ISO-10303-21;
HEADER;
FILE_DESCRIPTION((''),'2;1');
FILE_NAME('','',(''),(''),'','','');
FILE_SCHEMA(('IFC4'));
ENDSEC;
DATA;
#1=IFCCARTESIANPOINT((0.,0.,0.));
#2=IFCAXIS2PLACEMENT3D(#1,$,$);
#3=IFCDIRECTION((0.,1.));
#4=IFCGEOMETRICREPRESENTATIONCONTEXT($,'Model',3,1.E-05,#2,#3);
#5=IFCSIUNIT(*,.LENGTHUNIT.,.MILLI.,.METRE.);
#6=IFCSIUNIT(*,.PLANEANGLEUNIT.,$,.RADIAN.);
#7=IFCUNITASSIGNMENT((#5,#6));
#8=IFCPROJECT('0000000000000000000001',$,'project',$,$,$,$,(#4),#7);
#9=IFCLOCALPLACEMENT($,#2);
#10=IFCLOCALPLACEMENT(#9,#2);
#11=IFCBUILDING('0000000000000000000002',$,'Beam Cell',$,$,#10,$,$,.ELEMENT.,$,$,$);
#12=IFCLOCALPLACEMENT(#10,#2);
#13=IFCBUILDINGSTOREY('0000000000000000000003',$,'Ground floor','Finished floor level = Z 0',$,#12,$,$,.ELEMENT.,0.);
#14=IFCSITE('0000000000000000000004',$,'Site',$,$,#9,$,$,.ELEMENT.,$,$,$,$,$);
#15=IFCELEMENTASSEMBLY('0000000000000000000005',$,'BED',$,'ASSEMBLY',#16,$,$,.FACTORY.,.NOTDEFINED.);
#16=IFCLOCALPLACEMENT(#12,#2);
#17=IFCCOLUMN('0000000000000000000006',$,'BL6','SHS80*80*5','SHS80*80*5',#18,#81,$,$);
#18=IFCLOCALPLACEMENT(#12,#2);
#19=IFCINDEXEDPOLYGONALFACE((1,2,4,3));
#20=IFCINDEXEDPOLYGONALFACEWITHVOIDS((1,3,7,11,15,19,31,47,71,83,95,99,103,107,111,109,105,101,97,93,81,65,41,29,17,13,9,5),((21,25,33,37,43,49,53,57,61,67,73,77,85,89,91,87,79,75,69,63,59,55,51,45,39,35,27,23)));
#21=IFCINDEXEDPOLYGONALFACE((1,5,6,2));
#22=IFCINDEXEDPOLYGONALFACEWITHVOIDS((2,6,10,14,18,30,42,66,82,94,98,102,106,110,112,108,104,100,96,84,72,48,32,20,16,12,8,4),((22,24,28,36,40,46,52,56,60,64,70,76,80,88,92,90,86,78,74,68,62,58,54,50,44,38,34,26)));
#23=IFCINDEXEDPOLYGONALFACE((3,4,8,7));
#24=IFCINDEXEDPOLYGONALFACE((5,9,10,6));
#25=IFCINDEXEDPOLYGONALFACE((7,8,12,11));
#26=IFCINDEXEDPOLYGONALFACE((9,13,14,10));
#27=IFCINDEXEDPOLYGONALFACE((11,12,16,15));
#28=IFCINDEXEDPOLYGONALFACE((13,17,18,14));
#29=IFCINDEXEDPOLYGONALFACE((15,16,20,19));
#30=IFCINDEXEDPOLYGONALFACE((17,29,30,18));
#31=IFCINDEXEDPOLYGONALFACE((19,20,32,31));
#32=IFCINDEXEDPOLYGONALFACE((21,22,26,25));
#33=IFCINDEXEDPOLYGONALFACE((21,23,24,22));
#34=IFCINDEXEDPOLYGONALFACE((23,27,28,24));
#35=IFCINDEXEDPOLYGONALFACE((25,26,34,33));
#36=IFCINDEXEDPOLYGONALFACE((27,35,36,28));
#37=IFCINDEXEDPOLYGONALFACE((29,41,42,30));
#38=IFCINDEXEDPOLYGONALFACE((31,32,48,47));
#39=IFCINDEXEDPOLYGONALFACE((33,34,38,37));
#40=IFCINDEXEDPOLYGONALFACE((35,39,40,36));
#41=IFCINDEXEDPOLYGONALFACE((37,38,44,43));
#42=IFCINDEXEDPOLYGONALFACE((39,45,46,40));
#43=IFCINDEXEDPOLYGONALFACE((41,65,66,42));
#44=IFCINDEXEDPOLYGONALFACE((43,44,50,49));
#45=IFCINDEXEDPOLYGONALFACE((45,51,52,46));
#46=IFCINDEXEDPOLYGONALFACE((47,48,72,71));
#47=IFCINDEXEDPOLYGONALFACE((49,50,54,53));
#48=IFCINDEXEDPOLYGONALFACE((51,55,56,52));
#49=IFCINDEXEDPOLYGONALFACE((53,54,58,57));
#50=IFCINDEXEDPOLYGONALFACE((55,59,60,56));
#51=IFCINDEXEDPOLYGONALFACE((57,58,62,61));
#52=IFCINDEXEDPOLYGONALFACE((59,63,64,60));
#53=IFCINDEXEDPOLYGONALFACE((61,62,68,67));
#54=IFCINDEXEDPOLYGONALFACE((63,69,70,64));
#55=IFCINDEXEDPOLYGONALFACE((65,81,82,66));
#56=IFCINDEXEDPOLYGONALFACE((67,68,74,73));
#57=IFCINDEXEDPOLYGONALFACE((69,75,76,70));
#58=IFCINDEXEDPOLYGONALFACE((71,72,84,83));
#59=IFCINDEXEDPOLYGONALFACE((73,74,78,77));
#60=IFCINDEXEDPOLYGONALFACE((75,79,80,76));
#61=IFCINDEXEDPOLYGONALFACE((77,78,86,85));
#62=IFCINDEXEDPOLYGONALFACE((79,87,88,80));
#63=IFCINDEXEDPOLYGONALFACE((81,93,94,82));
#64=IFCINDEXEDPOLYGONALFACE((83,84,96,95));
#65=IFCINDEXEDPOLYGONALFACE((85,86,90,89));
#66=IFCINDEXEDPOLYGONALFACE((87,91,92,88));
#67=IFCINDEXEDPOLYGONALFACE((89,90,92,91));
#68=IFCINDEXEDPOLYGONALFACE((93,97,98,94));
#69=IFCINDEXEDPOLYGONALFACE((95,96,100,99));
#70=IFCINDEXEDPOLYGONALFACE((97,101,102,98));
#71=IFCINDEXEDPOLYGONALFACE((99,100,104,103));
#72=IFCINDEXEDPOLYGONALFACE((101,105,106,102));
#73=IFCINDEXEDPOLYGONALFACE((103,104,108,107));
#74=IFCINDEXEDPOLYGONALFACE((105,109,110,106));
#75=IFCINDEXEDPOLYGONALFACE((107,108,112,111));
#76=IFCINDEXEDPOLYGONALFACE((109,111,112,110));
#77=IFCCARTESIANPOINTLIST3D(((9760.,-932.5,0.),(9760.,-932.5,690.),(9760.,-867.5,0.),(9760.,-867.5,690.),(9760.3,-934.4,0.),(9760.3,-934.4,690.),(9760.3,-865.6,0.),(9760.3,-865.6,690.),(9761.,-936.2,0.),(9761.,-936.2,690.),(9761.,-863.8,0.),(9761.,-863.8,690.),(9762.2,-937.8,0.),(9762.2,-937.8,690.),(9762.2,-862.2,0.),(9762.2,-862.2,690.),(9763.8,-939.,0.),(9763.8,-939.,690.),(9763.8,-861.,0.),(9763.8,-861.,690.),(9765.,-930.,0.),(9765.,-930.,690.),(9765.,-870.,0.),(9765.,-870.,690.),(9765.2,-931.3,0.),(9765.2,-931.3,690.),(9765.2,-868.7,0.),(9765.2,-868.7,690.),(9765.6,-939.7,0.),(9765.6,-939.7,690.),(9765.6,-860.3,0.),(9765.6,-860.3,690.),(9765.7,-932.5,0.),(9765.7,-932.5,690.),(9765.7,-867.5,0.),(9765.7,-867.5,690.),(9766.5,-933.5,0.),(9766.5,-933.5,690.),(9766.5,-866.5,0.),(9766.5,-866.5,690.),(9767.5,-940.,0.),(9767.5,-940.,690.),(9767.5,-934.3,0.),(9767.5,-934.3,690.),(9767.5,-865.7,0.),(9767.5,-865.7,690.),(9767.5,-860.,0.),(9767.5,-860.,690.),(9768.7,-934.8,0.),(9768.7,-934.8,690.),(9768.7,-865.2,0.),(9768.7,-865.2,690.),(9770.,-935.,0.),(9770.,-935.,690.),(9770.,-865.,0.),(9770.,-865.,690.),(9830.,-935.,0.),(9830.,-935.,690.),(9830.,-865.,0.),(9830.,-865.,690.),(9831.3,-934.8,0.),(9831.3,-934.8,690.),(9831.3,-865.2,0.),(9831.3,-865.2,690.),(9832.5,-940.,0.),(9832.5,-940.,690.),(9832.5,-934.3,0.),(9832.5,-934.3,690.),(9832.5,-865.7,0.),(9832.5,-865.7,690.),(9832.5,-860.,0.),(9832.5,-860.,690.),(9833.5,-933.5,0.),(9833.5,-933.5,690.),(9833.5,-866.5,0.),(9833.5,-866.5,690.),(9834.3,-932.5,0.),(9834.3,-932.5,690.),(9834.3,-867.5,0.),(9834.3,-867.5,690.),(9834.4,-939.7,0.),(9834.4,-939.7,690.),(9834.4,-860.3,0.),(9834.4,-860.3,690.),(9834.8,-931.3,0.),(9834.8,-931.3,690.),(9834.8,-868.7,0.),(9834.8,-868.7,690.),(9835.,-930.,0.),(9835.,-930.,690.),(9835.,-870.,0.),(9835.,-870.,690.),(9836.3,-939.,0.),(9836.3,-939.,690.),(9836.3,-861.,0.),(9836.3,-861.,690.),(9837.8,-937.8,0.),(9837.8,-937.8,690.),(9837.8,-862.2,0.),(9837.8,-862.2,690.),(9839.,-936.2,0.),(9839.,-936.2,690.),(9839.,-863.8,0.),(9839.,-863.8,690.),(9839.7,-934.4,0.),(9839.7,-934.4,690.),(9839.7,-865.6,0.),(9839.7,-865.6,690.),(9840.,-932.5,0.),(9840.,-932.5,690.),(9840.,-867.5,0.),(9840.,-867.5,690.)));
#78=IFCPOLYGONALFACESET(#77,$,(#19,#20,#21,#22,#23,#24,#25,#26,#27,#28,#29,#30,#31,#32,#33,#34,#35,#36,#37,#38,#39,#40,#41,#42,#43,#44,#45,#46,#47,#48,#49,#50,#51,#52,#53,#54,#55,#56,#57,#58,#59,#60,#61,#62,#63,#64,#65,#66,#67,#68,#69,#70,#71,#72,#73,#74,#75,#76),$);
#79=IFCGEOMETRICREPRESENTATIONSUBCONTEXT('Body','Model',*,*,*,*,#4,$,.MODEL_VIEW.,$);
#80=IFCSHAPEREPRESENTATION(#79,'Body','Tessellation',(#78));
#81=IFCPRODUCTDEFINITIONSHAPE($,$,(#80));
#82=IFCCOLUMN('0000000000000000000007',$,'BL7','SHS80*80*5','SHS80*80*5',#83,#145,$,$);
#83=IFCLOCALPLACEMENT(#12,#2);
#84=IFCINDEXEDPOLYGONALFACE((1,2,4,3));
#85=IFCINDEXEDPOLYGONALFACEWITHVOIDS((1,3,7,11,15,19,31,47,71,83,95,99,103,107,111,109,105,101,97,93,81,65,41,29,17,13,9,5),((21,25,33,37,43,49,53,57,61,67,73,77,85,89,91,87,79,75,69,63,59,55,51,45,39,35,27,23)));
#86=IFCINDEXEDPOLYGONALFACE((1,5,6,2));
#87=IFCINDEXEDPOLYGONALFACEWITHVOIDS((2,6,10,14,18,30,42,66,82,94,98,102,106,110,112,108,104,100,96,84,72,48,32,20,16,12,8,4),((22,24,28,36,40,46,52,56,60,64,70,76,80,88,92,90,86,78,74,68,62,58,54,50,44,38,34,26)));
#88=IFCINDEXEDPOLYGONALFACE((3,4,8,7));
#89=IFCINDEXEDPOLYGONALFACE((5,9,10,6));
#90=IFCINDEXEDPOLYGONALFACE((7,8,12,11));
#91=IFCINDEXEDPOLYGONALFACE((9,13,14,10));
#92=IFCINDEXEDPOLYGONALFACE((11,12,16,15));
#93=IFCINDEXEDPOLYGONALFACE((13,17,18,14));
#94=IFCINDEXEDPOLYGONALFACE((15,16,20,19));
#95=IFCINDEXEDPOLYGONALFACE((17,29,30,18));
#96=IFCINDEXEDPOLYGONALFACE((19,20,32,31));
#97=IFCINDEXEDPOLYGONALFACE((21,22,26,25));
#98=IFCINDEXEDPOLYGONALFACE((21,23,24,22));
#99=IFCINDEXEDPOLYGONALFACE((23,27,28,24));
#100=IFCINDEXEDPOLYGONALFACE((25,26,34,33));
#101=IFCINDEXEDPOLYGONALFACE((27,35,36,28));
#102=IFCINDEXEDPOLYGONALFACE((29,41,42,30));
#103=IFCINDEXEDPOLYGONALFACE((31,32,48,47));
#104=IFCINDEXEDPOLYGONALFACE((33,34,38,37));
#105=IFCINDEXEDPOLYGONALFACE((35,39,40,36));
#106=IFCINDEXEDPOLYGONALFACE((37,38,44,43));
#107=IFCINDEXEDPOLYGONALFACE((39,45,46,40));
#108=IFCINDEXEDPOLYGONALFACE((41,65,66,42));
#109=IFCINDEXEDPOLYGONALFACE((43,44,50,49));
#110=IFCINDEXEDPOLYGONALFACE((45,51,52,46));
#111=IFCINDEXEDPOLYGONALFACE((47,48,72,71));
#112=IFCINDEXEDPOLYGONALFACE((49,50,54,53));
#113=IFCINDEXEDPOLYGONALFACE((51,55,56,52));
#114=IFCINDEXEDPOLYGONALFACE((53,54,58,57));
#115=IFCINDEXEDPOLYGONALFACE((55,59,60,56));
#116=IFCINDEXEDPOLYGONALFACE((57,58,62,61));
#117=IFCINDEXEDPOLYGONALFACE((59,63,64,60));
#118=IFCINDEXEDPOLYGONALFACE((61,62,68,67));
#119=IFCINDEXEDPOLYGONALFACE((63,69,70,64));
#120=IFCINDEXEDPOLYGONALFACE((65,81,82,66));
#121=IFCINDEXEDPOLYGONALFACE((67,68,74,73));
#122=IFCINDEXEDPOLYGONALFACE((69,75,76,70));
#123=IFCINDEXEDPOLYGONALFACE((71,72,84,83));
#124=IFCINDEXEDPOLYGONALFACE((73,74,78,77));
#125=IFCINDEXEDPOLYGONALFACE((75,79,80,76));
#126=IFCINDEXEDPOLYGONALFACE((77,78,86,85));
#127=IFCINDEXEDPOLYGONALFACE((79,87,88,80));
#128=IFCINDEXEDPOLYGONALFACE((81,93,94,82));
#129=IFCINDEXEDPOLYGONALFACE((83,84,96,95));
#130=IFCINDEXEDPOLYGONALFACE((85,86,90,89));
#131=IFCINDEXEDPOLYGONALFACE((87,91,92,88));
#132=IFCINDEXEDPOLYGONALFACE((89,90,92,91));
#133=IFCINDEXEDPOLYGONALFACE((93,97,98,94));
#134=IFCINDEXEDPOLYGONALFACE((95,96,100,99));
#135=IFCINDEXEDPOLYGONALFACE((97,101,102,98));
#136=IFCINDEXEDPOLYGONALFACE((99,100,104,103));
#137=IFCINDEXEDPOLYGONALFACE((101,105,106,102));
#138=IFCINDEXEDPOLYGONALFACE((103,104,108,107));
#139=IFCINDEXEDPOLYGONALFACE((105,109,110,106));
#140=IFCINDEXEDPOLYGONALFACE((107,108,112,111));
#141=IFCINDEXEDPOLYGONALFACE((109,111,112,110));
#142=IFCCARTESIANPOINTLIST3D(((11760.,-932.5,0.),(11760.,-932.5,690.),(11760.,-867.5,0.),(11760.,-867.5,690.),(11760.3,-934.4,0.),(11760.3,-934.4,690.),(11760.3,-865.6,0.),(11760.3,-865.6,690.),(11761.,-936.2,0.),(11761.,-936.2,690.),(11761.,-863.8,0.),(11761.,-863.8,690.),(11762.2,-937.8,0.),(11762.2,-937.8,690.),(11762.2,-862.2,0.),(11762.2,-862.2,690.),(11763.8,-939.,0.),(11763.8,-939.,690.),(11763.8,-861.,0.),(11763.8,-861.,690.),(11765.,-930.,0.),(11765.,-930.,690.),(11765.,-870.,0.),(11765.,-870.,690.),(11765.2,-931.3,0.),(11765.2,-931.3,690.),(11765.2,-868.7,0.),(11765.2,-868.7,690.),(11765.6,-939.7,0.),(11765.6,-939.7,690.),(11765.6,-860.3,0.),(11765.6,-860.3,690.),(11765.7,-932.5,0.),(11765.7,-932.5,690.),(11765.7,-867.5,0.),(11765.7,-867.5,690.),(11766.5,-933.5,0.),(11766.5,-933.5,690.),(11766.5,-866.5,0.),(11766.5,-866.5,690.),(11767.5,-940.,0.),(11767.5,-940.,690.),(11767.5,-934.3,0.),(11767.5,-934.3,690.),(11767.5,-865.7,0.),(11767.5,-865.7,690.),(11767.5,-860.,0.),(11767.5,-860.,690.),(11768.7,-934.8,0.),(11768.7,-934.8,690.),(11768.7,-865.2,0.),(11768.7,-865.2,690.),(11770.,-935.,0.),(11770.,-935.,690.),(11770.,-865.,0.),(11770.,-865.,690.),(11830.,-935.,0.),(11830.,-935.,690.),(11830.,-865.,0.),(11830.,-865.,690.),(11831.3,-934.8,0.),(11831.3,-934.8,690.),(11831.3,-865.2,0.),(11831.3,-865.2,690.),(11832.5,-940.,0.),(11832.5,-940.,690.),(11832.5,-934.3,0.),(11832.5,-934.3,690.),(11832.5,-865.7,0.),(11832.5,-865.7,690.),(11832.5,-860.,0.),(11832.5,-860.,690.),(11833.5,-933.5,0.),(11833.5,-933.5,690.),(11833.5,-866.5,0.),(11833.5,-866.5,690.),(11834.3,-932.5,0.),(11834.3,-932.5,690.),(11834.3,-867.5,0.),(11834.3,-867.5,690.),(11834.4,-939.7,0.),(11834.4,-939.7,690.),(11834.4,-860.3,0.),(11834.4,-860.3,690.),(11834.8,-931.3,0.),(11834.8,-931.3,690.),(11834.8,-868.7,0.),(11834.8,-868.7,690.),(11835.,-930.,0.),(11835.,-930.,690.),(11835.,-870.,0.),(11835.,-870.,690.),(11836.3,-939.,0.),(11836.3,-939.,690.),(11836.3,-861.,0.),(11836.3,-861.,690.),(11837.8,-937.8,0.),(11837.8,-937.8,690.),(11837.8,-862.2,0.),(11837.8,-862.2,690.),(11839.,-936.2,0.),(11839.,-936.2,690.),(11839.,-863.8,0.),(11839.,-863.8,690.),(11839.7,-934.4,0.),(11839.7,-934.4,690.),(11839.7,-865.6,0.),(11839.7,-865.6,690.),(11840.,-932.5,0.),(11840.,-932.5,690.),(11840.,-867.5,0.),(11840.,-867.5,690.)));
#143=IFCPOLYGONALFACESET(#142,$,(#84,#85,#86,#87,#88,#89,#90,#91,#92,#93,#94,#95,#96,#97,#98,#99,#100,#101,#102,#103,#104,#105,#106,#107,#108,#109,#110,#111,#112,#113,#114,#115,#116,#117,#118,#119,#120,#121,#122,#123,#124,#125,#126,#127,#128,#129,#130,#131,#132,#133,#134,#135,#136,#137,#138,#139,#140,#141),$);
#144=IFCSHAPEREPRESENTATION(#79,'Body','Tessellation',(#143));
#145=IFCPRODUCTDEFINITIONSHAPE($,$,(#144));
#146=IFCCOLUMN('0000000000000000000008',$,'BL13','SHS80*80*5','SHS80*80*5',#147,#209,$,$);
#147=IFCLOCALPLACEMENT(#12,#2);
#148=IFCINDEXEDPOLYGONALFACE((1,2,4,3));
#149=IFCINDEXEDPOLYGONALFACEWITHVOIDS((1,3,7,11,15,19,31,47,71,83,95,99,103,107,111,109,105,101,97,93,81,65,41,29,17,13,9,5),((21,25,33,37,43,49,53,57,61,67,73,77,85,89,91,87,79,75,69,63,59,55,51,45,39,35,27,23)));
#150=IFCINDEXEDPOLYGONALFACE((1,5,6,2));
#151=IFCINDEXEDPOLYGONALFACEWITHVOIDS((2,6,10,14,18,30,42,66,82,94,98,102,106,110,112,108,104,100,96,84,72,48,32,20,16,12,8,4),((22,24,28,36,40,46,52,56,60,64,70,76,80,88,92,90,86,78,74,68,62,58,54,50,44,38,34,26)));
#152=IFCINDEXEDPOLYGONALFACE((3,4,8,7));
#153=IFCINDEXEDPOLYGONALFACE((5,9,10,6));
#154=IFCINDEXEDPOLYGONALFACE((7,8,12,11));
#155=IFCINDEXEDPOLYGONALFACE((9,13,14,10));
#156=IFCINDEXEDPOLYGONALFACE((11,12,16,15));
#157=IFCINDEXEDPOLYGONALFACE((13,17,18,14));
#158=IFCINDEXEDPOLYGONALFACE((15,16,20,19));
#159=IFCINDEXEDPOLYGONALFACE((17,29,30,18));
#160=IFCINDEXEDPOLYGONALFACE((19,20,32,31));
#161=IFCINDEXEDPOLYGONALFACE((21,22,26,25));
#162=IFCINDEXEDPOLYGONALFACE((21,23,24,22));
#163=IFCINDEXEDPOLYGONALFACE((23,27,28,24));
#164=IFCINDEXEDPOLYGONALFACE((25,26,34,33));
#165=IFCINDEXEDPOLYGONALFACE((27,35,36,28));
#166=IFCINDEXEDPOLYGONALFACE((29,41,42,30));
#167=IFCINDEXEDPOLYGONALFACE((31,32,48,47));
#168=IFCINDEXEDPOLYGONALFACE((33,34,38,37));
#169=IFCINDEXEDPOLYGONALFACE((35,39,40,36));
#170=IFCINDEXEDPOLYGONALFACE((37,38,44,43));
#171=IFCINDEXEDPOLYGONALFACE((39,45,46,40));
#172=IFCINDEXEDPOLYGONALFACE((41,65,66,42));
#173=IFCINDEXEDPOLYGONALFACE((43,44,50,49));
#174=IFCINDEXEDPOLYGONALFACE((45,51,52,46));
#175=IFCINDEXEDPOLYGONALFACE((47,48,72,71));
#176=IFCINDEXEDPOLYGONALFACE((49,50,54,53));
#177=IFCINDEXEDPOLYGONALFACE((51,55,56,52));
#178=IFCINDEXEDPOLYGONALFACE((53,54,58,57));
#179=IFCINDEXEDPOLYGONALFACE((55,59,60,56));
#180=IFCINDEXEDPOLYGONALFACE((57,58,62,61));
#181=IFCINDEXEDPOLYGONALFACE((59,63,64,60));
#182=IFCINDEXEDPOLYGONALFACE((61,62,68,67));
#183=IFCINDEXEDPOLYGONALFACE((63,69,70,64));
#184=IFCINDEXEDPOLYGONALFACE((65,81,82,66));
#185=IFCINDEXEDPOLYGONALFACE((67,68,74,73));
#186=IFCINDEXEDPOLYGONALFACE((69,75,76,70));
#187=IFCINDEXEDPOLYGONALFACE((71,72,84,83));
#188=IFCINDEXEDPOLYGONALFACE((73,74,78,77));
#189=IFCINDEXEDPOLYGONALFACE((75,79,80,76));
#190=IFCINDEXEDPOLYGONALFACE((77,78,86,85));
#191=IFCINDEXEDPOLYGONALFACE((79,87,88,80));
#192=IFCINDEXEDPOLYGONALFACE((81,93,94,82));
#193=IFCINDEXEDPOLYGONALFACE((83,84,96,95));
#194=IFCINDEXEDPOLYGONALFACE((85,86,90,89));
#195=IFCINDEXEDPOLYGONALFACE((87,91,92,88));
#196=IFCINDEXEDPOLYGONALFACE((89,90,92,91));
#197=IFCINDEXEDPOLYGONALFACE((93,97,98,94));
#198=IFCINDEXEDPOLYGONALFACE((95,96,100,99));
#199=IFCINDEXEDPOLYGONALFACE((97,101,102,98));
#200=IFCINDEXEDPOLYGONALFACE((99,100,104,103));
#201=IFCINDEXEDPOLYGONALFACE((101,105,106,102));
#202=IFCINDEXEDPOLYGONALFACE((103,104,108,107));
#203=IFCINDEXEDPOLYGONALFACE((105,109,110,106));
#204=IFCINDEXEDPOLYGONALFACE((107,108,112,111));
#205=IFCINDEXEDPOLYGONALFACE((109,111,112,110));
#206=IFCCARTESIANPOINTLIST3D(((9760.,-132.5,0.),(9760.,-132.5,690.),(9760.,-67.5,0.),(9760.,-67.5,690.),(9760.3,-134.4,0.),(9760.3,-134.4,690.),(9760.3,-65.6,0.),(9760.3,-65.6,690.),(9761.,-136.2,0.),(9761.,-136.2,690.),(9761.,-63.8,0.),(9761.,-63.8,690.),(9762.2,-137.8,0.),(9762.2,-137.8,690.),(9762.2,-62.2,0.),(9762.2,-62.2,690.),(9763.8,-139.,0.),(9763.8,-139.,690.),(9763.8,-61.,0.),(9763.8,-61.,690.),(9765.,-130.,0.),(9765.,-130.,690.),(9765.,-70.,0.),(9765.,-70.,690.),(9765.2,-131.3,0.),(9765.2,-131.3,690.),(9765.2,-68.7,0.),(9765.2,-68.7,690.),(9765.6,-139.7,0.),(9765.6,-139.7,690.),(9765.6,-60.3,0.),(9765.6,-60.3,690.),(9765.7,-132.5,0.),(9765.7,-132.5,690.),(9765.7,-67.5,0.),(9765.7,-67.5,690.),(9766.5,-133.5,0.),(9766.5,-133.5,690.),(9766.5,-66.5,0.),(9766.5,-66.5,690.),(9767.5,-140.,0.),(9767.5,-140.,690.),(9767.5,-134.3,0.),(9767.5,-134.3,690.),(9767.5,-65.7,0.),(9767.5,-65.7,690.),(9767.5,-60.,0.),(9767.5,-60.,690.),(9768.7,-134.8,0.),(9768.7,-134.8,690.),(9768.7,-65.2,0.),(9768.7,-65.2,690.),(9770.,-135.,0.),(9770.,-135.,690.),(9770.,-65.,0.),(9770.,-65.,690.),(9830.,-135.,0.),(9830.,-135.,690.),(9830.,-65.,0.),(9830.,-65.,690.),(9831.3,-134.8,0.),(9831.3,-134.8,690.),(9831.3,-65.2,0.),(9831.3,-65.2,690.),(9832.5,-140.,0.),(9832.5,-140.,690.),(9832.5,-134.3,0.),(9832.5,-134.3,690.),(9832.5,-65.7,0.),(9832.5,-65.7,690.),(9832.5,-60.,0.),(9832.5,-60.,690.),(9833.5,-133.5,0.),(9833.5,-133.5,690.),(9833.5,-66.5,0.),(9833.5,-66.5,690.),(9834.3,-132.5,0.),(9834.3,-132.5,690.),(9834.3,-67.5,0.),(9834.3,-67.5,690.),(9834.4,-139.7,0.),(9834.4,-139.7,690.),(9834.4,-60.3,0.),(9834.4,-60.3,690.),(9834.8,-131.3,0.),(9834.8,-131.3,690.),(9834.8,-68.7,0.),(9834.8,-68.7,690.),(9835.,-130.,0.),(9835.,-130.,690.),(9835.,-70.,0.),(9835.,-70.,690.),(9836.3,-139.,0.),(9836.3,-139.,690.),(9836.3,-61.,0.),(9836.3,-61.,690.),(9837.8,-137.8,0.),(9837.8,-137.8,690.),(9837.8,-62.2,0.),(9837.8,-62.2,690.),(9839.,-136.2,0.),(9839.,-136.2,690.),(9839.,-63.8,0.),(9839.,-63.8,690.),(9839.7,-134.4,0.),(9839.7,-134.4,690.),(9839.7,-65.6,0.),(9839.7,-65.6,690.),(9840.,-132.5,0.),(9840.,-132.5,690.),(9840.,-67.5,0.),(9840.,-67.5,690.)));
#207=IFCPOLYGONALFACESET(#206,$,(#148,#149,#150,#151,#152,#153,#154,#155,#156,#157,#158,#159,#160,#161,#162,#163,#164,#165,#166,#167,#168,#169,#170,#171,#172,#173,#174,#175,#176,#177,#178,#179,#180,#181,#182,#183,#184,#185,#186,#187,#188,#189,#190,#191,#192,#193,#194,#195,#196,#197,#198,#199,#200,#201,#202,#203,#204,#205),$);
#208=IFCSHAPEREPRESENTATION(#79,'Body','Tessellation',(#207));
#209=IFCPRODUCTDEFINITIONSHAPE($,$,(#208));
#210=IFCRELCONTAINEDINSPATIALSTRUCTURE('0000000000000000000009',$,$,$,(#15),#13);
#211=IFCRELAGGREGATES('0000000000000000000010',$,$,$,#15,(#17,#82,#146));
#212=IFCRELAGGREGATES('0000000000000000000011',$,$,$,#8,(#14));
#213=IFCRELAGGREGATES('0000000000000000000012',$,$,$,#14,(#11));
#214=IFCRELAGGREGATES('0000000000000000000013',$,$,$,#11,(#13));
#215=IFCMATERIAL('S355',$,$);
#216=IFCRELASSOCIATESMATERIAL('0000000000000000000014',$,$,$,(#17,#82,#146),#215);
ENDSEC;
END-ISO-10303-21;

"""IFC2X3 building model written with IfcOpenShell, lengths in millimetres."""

from ifc_helpers import new_model, si_unit, direction, frame, origin, origin_2d, place, context, subcontext, project, spatial, hollow_rectangle, extrude, material, element, aggregate, save


model = new_model("IFC2X3")

# Units and contexts
model_context = context("Model", 3, precision=1e-05, world=origin(), true_north=direction((0.0, 1.0)))
body_context = subcontext(model_context, "Body", "Model", "MODEL_VIEW")
ifc_project = project(units=[si_unit("LENGTHUNIT", "METRE", prefix="MILLI"), si_unit("PLANEANGLEUNIT", "RADIAN")], contexts=[model_context])

# Site, building, storey
site_placement = place(None, origin())
site = spatial("IfcSite", under=ifc_project, at=site_placement, Name="Site", CompositionType="ELEMENT")
building_placement = place(site_placement, origin())
building = spatial("IfcBuilding", under=site, at=building_placement, Name="Beam Cell", CompositionType="ELEMENT")
storey_placement = place(building_placement, origin())
storey = spatial("IfcBuildingStorey", under=building, at=storey_placement, Name="Ground floor", Description="Finished floor level = Z 0", CompositionType="ELEMENT", Elevation=0.0)

# Element assembly, columns
ifc_material = material(Name="S355")
assembly_1_placement = place(storey_placement, origin())
assembly_1 = element("IfcElementAssembly", 1, at=assembly_1_placement, inside=storey, Name="BED", ObjectType="ASSEMBLY", AssemblyPlace="FACTORY", PredefinedType="NOTDEFINED")
column_1_placement = place(storey_placement, frame((9800.0, -900.0, 0.0), z_axis=(0.0, 0.0, 1.0), x_axis=(1.0, 0.0, 0.0)))
column_1 = element("IfcColumn", 2, at=column_1_placement, material=ifc_material, Name="BL6", Description="SHS80*80*5", ObjectType="SHS80*80*5", context=body_context, shape_type="SweptSolid", body=[
    extrude(hollow_rectangle(XDim=80.0, YDim=80.0, WallThickness=5.0, InnerFilletRadius=5.0, OuterFilletRadius=7.5, at=origin_2d()), origin(), (0.0, 0.0, 1.0), 690.0),
])
column_2_placement = place(storey_placement, frame((11800.0, -900.0, 0.0), z_axis=(0.0, 0.0, 1.0), x_axis=(1.0, 0.0, 0.0)))
column_2 = element("IfcColumn", 3, at=column_2_placement, material=ifc_material, Name="BL7", Description="SHS80*80*5", ObjectType="SHS80*80*5", context=body_context, shape_type="SweptSolid", body=[
    extrude(hollow_rectangle(XDim=80.0, YDim=80.0, WallThickness=5.0, InnerFilletRadius=5.0, OuterFilletRadius=7.5, at=origin_2d()), origin(), (0.0, 0.0, 1.0), 690.0),
])
column_3_placement = place(storey_placement, frame((9800.0, -100.0, 0.0), z_axis=(0.0, 0.0, 1.0), x_axis=(1.0, 0.0, 0.0)))
column_3 = element("IfcColumn", 4, at=column_3_placement, material=ifc_material, Name="BL13", Description="SHS80*80*5", ObjectType="SHS80*80*5", context=body_context, shape_type="SweptSolid", body=[
    extrude(hollow_rectangle(XDim=80.0, YDim=80.0, WallThickness=5.0, InnerFilletRadius=5.0, OuterFilletRadius=7.5, at=origin_2d()), origin(), (0.0, 0.0, 1.0), 690.0),
])
aggregate(assembly_1, [column_1, column_2, column_3])

save(model, "model.ifc")
